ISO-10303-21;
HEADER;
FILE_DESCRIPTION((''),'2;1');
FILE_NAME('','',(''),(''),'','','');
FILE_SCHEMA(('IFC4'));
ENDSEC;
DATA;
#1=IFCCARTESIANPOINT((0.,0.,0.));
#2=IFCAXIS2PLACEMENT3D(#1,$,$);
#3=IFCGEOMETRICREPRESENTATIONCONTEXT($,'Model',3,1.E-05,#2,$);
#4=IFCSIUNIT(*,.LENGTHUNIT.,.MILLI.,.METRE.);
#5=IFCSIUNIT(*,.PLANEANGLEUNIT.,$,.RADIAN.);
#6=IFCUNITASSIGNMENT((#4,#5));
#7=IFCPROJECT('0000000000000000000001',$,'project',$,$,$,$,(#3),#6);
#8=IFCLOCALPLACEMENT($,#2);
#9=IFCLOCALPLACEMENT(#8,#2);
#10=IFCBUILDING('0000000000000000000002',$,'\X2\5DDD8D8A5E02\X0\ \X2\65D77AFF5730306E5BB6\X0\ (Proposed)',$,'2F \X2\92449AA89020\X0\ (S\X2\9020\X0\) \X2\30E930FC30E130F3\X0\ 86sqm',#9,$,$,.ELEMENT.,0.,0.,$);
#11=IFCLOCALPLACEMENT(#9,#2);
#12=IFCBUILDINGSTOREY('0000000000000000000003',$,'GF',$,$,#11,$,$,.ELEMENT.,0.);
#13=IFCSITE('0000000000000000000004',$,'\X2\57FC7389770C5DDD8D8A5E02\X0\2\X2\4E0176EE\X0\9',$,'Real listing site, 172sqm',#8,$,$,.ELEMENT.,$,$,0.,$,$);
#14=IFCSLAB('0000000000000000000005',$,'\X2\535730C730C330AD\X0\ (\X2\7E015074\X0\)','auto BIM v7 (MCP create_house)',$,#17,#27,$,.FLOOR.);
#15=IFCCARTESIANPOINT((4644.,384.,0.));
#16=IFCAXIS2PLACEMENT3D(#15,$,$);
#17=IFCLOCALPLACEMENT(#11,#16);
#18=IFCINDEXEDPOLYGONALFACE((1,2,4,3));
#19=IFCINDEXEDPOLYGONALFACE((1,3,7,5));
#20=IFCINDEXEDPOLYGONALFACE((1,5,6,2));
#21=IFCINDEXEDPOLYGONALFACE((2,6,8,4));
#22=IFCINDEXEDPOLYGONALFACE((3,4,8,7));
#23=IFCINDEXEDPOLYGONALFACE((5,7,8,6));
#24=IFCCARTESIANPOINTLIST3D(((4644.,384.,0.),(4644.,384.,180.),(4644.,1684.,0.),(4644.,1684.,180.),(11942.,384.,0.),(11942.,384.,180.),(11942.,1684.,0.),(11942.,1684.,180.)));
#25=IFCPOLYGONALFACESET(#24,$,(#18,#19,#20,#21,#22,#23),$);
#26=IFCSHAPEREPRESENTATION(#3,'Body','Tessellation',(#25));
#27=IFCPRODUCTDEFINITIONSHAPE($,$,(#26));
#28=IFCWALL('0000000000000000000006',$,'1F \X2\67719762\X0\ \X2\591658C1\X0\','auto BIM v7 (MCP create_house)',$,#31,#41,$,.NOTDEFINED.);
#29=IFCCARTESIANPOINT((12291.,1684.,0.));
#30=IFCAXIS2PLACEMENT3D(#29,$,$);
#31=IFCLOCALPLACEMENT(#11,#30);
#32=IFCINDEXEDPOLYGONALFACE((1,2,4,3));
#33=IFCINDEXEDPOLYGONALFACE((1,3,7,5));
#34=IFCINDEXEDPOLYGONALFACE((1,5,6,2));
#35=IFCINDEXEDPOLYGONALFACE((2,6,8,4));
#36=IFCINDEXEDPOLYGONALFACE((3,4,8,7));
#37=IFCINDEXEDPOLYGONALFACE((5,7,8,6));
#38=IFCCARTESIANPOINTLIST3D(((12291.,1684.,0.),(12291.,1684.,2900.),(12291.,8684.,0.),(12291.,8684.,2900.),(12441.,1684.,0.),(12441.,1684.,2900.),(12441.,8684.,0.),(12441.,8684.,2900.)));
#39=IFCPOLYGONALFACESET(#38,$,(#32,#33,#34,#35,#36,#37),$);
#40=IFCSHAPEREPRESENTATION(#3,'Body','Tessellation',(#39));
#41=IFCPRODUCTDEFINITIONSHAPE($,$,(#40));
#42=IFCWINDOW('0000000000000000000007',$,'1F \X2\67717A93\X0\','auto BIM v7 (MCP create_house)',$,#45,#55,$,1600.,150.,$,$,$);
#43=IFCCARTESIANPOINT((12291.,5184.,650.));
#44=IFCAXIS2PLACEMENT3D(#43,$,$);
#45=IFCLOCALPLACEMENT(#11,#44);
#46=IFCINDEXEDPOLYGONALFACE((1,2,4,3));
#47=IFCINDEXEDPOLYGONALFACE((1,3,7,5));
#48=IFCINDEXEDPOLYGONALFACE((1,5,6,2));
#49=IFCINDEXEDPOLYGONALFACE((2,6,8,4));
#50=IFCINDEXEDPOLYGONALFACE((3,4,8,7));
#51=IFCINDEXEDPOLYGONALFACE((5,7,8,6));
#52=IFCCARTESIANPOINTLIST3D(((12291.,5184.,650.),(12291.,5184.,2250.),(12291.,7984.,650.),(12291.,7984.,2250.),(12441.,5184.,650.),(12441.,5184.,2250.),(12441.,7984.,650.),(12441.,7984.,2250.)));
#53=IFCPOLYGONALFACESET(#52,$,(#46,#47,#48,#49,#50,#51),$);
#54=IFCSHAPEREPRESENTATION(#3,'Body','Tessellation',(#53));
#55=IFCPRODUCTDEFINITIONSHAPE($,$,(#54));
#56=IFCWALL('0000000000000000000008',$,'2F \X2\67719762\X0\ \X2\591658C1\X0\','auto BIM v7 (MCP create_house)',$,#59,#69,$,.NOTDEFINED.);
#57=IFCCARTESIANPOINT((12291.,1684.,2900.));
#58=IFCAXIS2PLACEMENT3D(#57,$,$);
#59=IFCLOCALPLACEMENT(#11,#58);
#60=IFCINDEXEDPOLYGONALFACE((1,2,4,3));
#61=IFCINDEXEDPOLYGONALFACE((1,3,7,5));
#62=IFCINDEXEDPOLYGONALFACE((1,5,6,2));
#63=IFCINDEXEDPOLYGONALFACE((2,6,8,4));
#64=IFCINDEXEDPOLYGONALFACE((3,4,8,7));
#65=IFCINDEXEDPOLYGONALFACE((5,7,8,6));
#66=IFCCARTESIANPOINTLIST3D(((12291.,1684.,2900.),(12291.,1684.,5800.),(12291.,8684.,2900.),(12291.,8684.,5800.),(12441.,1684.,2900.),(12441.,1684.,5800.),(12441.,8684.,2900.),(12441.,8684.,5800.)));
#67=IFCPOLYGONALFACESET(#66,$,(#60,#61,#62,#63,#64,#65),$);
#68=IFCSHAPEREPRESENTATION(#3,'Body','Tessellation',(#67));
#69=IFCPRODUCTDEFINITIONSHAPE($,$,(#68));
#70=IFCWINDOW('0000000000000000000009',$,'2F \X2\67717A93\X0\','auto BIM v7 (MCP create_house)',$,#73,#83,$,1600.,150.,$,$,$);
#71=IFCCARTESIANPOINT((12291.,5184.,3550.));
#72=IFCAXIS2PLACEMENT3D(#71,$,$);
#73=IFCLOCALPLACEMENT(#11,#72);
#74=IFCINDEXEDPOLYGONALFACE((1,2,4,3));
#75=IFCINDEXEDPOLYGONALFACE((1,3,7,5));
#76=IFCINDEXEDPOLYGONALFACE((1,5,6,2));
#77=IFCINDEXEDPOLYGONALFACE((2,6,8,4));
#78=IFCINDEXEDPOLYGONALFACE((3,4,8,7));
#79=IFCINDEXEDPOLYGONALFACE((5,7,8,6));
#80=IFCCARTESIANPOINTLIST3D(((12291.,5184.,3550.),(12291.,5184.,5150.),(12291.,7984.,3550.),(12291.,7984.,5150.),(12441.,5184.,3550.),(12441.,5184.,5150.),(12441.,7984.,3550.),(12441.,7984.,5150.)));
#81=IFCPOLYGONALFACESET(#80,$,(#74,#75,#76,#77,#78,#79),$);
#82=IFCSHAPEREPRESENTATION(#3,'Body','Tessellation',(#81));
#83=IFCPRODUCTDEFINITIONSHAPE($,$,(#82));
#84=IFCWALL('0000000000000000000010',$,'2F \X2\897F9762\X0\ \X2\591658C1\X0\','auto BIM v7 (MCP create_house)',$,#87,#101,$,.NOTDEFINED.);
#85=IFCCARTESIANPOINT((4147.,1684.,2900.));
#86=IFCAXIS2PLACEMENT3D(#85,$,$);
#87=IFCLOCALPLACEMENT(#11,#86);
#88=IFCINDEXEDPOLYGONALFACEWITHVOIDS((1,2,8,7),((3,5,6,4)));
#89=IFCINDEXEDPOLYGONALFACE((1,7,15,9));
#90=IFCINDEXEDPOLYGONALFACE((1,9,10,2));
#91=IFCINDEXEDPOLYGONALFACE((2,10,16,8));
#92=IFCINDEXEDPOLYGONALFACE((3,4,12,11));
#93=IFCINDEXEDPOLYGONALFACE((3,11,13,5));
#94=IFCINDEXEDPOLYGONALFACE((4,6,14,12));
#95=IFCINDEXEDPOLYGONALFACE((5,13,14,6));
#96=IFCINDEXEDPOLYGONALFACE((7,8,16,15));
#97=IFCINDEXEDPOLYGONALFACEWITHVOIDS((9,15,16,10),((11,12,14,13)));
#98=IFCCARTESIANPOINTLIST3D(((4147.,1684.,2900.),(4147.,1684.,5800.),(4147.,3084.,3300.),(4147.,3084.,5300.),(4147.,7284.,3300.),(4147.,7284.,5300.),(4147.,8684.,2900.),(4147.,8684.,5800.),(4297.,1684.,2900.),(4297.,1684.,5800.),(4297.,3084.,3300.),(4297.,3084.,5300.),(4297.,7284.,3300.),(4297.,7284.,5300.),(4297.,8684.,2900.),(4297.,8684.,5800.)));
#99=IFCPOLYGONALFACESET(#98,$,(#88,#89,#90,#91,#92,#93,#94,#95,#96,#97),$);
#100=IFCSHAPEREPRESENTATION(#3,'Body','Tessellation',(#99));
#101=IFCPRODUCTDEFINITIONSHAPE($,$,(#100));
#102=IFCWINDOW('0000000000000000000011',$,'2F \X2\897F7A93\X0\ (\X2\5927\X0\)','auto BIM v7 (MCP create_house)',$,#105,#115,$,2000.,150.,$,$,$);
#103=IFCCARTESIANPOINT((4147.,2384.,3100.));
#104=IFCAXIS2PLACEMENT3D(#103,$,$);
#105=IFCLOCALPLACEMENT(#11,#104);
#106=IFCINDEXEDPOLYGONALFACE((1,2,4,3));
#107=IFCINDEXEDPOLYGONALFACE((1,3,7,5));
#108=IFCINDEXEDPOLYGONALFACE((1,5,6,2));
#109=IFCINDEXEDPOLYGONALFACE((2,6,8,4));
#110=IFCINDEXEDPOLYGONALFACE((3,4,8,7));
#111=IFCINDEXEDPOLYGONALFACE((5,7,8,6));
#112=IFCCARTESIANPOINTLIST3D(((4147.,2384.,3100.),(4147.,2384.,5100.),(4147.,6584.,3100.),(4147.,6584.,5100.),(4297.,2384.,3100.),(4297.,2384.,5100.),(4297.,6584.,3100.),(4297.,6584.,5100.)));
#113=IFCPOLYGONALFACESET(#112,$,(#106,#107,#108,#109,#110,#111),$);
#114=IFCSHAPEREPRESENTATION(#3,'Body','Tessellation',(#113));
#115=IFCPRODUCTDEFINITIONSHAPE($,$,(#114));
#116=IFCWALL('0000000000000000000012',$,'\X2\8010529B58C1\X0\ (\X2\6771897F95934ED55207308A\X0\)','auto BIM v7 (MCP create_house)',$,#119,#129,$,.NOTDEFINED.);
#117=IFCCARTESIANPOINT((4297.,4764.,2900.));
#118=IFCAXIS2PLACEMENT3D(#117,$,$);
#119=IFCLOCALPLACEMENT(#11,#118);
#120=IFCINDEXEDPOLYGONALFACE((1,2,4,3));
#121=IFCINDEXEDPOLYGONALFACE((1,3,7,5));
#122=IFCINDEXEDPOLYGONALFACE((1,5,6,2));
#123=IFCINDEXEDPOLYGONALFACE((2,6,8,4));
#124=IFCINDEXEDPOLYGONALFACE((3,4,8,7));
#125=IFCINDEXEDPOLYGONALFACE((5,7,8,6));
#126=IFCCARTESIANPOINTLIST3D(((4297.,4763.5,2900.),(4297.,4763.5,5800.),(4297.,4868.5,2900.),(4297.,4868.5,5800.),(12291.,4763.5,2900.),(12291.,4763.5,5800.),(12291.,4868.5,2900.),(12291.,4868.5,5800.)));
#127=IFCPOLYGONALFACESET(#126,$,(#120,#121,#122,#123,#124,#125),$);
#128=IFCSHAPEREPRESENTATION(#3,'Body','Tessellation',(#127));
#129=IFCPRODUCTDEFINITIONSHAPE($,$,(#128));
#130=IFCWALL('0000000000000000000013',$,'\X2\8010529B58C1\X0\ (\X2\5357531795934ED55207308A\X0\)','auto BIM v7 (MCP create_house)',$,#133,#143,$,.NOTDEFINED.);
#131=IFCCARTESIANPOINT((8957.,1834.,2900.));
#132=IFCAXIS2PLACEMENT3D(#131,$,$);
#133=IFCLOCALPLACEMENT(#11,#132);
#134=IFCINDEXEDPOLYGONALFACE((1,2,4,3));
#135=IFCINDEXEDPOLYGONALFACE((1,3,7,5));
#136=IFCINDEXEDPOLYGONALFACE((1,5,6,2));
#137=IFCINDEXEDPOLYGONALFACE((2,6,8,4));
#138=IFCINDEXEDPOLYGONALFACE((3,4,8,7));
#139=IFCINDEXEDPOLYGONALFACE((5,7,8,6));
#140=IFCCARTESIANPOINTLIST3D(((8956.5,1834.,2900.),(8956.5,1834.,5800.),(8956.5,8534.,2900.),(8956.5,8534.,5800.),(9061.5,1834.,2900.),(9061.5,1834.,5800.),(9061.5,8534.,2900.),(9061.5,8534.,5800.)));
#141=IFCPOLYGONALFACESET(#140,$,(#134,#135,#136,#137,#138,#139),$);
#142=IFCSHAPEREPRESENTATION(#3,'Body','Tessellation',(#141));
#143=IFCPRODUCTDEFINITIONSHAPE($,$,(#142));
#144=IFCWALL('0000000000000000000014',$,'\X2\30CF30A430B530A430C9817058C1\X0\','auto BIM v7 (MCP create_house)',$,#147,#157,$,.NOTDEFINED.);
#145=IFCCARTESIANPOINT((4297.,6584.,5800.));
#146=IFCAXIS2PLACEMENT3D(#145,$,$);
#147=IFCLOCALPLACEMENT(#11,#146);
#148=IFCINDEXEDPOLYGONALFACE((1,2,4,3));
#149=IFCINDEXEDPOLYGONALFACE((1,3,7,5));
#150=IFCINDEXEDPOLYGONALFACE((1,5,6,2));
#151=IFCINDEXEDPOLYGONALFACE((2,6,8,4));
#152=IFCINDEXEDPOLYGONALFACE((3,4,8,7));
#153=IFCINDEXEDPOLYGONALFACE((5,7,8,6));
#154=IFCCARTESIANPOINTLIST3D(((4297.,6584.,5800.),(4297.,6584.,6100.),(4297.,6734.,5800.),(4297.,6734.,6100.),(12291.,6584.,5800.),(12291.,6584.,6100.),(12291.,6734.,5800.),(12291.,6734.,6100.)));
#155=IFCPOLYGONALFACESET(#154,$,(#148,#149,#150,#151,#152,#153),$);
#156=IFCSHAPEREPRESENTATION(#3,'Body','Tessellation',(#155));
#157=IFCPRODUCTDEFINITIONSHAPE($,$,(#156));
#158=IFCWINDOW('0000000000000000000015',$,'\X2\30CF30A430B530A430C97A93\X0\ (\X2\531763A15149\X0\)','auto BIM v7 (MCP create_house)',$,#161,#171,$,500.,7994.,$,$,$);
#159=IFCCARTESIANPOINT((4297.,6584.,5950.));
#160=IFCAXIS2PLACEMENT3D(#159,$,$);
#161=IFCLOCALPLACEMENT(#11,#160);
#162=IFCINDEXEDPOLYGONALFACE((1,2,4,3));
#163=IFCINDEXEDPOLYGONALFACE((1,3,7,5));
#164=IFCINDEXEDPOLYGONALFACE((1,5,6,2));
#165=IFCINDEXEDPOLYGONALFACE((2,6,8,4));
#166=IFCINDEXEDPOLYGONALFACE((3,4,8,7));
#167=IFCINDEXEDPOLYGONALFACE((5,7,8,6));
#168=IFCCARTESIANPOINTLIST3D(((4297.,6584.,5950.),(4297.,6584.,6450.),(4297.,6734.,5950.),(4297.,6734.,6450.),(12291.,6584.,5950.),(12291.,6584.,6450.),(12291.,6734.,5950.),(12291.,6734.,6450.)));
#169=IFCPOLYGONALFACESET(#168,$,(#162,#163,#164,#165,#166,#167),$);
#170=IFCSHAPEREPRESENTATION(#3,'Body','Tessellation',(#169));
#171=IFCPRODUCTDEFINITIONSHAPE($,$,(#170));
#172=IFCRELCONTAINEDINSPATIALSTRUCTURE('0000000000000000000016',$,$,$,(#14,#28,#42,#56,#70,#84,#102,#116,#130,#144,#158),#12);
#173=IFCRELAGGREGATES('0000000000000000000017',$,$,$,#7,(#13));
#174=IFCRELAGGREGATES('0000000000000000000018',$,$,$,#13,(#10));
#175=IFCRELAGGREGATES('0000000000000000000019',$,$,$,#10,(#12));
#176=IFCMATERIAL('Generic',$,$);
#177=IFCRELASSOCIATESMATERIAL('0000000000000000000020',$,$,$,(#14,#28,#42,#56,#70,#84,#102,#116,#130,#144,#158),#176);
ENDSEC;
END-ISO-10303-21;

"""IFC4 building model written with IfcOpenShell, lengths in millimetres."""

from ifc_helpers import new_model, si_unit, frame, frame_2d, origin, place, context, project, spatial, rectangle, extrude, material, element, fill, save


model = new_model("IFC4")

# Units and contexts
model_context = context("Model", 3, precision=1e-05, world=origin())
ifc_project = project(units=[si_unit("LENGTHUNIT", "METRE", prefix="MILLI"), si_unit("PLANEANGLEUNIT", "RADIAN")], contexts=[model_context])

# Site, building, storey
site_placement = place(None, origin())
site = spatial("IfcSite", under=ifc_project, at=site_placement, Name="埼玉県川越市2丁目9", ObjectType="Real listing site, 172sqm", CompositionType="ELEMENT", RefElevation=0.0)
building_placement = place(site_placement, origin())
building = spatial("IfcBuilding", under=site, at=building_placement, Name="川越市 旗竿地の家 (Proposed)", ObjectType="2F 鉄骨造 (S造) ラーメン 86sqm", CompositionType="ELEMENT", ElevationOfRefHeight=0.0, ElevationOfTerrain=0.0)
storey_placement = place(building_placement, origin())
storey = spatial("IfcBuildingStorey", under=building, at=storey_placement, Name="GF", CompositionType="ELEMENT", Elevation=0.0)

# Slab
ifc_material = material(Name="Generic")
slab_placement = place(storey_placement, frame((4644.0, 384.0, 0.0)))
element("IfcSlab", 1, at=slab_placement, inside=storey, material=ifc_material, Name="南デッキ (縁側)", Description="auto BIM v7 (MCP create_house)", PredefinedType="FLOOR", context=model_context, shape_type="SweptSolid", body=[
    extrude(rectangle(XDim=7298.0, YDim=1300.0, at=frame_2d((3649.0, 650.0))), frame((4644.0, 384.0, 0.0)), (0.0, 0.0, 1.0), 180.0),
])

# Wall, opening, window
wall_1_placement = place(storey_placement, frame((12291.0, 1684.0, 0.0)))
wall_1 = element("IfcWall", 2, at=wall_1_placement, inside=storey, material=ifc_material, Name="1F 東面 外壁", Description="auto BIM v7 (MCP create_house)", PredefinedType="NOTDEFINED", context=model_context, shape_type="SweptSolid", body=[
    extrude(rectangle(XDim=150.0, YDim=7000.0, at=frame_2d((75.0, 3500.0))), frame((12291.0, 1684.0, 0.0)), (0.0, 0.0, 1.0), 2900.0),
])
opening_1_placement = place(storey_placement, frame((12291.0, 5184.0, 650.0)))
opening_1 = element("IfcOpeningElement", 3, at=opening_1_placement, cuts=wall_1, PredefinedType="NOTDEFINED", context=model_context, shape_type="SweptSolid", body=[
    extrude(rectangle(XDim=150.0, YDim=2800.0, at=frame_2d((75.0, 1400.0))), frame((12291.0, 5184.0, 650.0)), (0.0, 0.0, 1.0), 1600.0),
])
window_1_placement = place(storey_placement, frame((12291.0, 5184.0, 650.0)))
window_1 = element("IfcWindow", 4, at=window_1_placement, inside=storey, material=ifc_material, Name="1F 東窓", Description="auto BIM v7 (MCP create_house)", OverallHeight=1600.0, OverallWidth=150.0, context=model_context, shape_type="SweptSolid", body=[
    extrude(rectangle(XDim=150.0, YDim=2800.0, at=frame_2d((75.0, 1400.0))), frame((12291.0, 5184.0, 650.0)), (0.0, 0.0, 1.0), 1600.0),
])
fill(opening_1, window_1)

# Walls, openings, windows
wall_2_placement = place(storey_placement, frame((12291.0, 1684.0, 2900.0)))
wall_2 = element("IfcWall", 5, at=wall_2_placement, inside=storey, material=ifc_material, Name="2F 東面 外壁", Description="auto BIM v7 (MCP create_house)", PredefinedType="NOTDEFINED", context=model_context, shape_type="SweptSolid", body=[
    extrude(rectangle(XDim=150.0, YDim=7000.0, at=frame_2d((75.0, 3500.0))), frame((12291.0, 1684.0, 2900.0)), (0.0, 0.0, 1.0), 2900.0),
])
opening_2_placement = place(storey_placement, frame((12291.0, 5184.0, 3550.0)))
opening_2 = element("IfcOpeningElement", 6, at=opening_2_placement, cuts=wall_2, PredefinedType="NOTDEFINED", context=model_context, shape_type="SweptSolid", body=[
    extrude(rectangle(XDim=150.0, YDim=2800.0, at=frame_2d((75.0, 1400.0))), frame((12291.0, 5184.0, 3550.0)), (0.0, 0.0, 1.0), 1600.0),
])
window_2_placement = place(storey_placement, frame((12291.0, 5184.0, 3550.0)))
window_2 = element("IfcWindow", 7, at=window_2_placement, inside=storey, material=ifc_material, Name="2F 東窓", Description="auto BIM v7 (MCP create_house)", OverallHeight=1600.0, OverallWidth=150.0, context=model_context, shape_type="SweptSolid", body=[
    extrude(rectangle(XDim=150.0, YDim=2800.0, at=frame_2d((75.0, 1400.0))), frame((12291.0, 5184.0, 3550.0)), (0.0, 0.0, 1.0), 1600.0),
])
fill(opening_2, window_2)
wall_3_placement = place(storey_placement, frame((4147.0, 1684.0, 2900.0)))
wall_3 = element("IfcWall", 8, at=wall_3_placement, inside=storey, material=ifc_material, Name="2F 西面 外壁", Description="auto BIM v7 (MCP create_house)", PredefinedType="NOTDEFINED", context=model_context, shape_type="SweptSolid", body=[
    extrude(rectangle(XDim=150.0, YDim=7000.0, at=frame_2d((75.0, 3500.0))), frame((4147.0, 1684.0, 2900.0)), (0.0, 0.0, 1.0), 2900.0),
])
opening_3_placement = place(storey_placement, frame((4147.0, 2384.0, 3100.0)))
opening_3 = element("IfcOpeningElement", 9, at=opening_3_placement, cuts=wall_3, PredefinedType="NOTDEFINED", context=model_context, shape_type="SweptSolid", body=[
    extrude(rectangle(XDim=150.0, YDim=4200.0, at=frame_2d((75.0, 2100.0))), frame((4147.0, 2384.0, 3100.0)), (0.0, 0.0, 1.0), 2000.0),
])
window_3_placement = place(storey_placement, frame((4147.0, 2384.0, 3100.0)))
window_3 = element("IfcWindow", 10, at=window_3_placement, inside=storey, material=ifc_material, Name="2F 西窓 (大)", Description="auto BIM v7 (MCP create_house)", OverallHeight=2000.0, OverallWidth=150.0, context=model_context, shape_type="SweptSolid", body=[
    extrude(rectangle(XDim=150.0, YDim=4200.0, at=frame_2d((75.0, 2100.0))), frame((4147.0, 2384.0, 3100.0)), (0.0, 0.0, 1.0), 2000.0),
])
fill(opening_3, window_3)

# Walls
wall_4_placement = place(storey_placement, frame((4297.0, 4764.0, 2900.0)))
element("IfcWall", 11, at=wall_4_placement, inside=storey, material=ifc_material, Name="耐力壁 (東西間仕切り)", Description="auto BIM v7 (MCP create_house)", PredefinedType="NOTDEFINED", context=model_context, shape_type="SweptSolid", body=[
    extrude(rectangle(XDim=7994.0, YDim=105.0, at=frame_2d((3997.0, 52.0))), frame((4297.0, 4764.0, 2900.0)), (0.0, 0.0, 1.0), 2900.0),
])
wall_5_placement = place(storey_placement, frame((8957.0, 1834.0, 2900.0)))
element("IfcWall", 12, at=wall_5_placement, inside=storey, material=ifc_material, Name="耐力壁 (南北間仕切り)", Description="auto BIM v7 (MCP create_house)", PredefinedType="NOTDEFINED", context=model_context, shape_type="SweptSolid", body=[
    extrude(rectangle(XDim=105.0, YDim=6700.0, at=frame_2d((52.0, 3350.0))), frame((8957.0, 1834.0, 2900.0)), (0.0, 0.0, 1.0), 2900.0),
])

# Wall, opening, window
wall_6_placement = place(storey_placement, frame((4297.0, 6584.0, 5800.0)))
wall_6 = element("IfcWall", 13, at=wall_6_placement, inside=storey, material=ifc_material, Name="ハイサイド腰壁", Description="auto BIM v7 (MCP create_house)", PredefinedType="NOTDEFINED", context=model_context, shape_type="SweptSolid", body=[
    extrude(rectangle(XDim=7994.0, YDim=150.0, at=frame_2d((3997.0, 75.0))), frame((4297.0, 6584.0, 5800.0)), (0.0, 0.0, 1.0), 700.0),
])
opening_4_placement = place(storey_placement, frame((4297.0, 6584.0, 5950.0)))
opening_4 = element("IfcOpeningElement", 14, at=opening_4_placement, cuts=wall_6, PredefinedType="NOTDEFINED", context=model_context, shape_type="SweptSolid", body=[
    extrude(rectangle(XDim=7994.0, YDim=150.0, at=frame_2d((3997.0, 75.0))), frame((4297.0, 6584.0, 5950.0)), (0.0, 0.0, 1.0), 500.0),
])
window_4_placement = place(storey_placement, frame((4297.0, 6584.0, 5950.0)))
window_4 = element("IfcWindow", 15, at=window_4_placement, inside=storey, material=ifc_material, Name="ハイサイド窓 (北採光)", Description="auto BIM v7 (MCP create_house)", OverallHeight=500.0, OverallWidth=7994.0, context=model_context, shape_type="SweptSolid", body=[
    extrude(rectangle(XDim=7994.0, YDim=150.0, at=frame_2d((3997.0, 75.0))), frame((4297.0, 6584.0, 5950.0)), (0.0, 0.0, 1.0), 500.0),
])
fill(opening_4, window_4)

save(model, "model.ifc")
